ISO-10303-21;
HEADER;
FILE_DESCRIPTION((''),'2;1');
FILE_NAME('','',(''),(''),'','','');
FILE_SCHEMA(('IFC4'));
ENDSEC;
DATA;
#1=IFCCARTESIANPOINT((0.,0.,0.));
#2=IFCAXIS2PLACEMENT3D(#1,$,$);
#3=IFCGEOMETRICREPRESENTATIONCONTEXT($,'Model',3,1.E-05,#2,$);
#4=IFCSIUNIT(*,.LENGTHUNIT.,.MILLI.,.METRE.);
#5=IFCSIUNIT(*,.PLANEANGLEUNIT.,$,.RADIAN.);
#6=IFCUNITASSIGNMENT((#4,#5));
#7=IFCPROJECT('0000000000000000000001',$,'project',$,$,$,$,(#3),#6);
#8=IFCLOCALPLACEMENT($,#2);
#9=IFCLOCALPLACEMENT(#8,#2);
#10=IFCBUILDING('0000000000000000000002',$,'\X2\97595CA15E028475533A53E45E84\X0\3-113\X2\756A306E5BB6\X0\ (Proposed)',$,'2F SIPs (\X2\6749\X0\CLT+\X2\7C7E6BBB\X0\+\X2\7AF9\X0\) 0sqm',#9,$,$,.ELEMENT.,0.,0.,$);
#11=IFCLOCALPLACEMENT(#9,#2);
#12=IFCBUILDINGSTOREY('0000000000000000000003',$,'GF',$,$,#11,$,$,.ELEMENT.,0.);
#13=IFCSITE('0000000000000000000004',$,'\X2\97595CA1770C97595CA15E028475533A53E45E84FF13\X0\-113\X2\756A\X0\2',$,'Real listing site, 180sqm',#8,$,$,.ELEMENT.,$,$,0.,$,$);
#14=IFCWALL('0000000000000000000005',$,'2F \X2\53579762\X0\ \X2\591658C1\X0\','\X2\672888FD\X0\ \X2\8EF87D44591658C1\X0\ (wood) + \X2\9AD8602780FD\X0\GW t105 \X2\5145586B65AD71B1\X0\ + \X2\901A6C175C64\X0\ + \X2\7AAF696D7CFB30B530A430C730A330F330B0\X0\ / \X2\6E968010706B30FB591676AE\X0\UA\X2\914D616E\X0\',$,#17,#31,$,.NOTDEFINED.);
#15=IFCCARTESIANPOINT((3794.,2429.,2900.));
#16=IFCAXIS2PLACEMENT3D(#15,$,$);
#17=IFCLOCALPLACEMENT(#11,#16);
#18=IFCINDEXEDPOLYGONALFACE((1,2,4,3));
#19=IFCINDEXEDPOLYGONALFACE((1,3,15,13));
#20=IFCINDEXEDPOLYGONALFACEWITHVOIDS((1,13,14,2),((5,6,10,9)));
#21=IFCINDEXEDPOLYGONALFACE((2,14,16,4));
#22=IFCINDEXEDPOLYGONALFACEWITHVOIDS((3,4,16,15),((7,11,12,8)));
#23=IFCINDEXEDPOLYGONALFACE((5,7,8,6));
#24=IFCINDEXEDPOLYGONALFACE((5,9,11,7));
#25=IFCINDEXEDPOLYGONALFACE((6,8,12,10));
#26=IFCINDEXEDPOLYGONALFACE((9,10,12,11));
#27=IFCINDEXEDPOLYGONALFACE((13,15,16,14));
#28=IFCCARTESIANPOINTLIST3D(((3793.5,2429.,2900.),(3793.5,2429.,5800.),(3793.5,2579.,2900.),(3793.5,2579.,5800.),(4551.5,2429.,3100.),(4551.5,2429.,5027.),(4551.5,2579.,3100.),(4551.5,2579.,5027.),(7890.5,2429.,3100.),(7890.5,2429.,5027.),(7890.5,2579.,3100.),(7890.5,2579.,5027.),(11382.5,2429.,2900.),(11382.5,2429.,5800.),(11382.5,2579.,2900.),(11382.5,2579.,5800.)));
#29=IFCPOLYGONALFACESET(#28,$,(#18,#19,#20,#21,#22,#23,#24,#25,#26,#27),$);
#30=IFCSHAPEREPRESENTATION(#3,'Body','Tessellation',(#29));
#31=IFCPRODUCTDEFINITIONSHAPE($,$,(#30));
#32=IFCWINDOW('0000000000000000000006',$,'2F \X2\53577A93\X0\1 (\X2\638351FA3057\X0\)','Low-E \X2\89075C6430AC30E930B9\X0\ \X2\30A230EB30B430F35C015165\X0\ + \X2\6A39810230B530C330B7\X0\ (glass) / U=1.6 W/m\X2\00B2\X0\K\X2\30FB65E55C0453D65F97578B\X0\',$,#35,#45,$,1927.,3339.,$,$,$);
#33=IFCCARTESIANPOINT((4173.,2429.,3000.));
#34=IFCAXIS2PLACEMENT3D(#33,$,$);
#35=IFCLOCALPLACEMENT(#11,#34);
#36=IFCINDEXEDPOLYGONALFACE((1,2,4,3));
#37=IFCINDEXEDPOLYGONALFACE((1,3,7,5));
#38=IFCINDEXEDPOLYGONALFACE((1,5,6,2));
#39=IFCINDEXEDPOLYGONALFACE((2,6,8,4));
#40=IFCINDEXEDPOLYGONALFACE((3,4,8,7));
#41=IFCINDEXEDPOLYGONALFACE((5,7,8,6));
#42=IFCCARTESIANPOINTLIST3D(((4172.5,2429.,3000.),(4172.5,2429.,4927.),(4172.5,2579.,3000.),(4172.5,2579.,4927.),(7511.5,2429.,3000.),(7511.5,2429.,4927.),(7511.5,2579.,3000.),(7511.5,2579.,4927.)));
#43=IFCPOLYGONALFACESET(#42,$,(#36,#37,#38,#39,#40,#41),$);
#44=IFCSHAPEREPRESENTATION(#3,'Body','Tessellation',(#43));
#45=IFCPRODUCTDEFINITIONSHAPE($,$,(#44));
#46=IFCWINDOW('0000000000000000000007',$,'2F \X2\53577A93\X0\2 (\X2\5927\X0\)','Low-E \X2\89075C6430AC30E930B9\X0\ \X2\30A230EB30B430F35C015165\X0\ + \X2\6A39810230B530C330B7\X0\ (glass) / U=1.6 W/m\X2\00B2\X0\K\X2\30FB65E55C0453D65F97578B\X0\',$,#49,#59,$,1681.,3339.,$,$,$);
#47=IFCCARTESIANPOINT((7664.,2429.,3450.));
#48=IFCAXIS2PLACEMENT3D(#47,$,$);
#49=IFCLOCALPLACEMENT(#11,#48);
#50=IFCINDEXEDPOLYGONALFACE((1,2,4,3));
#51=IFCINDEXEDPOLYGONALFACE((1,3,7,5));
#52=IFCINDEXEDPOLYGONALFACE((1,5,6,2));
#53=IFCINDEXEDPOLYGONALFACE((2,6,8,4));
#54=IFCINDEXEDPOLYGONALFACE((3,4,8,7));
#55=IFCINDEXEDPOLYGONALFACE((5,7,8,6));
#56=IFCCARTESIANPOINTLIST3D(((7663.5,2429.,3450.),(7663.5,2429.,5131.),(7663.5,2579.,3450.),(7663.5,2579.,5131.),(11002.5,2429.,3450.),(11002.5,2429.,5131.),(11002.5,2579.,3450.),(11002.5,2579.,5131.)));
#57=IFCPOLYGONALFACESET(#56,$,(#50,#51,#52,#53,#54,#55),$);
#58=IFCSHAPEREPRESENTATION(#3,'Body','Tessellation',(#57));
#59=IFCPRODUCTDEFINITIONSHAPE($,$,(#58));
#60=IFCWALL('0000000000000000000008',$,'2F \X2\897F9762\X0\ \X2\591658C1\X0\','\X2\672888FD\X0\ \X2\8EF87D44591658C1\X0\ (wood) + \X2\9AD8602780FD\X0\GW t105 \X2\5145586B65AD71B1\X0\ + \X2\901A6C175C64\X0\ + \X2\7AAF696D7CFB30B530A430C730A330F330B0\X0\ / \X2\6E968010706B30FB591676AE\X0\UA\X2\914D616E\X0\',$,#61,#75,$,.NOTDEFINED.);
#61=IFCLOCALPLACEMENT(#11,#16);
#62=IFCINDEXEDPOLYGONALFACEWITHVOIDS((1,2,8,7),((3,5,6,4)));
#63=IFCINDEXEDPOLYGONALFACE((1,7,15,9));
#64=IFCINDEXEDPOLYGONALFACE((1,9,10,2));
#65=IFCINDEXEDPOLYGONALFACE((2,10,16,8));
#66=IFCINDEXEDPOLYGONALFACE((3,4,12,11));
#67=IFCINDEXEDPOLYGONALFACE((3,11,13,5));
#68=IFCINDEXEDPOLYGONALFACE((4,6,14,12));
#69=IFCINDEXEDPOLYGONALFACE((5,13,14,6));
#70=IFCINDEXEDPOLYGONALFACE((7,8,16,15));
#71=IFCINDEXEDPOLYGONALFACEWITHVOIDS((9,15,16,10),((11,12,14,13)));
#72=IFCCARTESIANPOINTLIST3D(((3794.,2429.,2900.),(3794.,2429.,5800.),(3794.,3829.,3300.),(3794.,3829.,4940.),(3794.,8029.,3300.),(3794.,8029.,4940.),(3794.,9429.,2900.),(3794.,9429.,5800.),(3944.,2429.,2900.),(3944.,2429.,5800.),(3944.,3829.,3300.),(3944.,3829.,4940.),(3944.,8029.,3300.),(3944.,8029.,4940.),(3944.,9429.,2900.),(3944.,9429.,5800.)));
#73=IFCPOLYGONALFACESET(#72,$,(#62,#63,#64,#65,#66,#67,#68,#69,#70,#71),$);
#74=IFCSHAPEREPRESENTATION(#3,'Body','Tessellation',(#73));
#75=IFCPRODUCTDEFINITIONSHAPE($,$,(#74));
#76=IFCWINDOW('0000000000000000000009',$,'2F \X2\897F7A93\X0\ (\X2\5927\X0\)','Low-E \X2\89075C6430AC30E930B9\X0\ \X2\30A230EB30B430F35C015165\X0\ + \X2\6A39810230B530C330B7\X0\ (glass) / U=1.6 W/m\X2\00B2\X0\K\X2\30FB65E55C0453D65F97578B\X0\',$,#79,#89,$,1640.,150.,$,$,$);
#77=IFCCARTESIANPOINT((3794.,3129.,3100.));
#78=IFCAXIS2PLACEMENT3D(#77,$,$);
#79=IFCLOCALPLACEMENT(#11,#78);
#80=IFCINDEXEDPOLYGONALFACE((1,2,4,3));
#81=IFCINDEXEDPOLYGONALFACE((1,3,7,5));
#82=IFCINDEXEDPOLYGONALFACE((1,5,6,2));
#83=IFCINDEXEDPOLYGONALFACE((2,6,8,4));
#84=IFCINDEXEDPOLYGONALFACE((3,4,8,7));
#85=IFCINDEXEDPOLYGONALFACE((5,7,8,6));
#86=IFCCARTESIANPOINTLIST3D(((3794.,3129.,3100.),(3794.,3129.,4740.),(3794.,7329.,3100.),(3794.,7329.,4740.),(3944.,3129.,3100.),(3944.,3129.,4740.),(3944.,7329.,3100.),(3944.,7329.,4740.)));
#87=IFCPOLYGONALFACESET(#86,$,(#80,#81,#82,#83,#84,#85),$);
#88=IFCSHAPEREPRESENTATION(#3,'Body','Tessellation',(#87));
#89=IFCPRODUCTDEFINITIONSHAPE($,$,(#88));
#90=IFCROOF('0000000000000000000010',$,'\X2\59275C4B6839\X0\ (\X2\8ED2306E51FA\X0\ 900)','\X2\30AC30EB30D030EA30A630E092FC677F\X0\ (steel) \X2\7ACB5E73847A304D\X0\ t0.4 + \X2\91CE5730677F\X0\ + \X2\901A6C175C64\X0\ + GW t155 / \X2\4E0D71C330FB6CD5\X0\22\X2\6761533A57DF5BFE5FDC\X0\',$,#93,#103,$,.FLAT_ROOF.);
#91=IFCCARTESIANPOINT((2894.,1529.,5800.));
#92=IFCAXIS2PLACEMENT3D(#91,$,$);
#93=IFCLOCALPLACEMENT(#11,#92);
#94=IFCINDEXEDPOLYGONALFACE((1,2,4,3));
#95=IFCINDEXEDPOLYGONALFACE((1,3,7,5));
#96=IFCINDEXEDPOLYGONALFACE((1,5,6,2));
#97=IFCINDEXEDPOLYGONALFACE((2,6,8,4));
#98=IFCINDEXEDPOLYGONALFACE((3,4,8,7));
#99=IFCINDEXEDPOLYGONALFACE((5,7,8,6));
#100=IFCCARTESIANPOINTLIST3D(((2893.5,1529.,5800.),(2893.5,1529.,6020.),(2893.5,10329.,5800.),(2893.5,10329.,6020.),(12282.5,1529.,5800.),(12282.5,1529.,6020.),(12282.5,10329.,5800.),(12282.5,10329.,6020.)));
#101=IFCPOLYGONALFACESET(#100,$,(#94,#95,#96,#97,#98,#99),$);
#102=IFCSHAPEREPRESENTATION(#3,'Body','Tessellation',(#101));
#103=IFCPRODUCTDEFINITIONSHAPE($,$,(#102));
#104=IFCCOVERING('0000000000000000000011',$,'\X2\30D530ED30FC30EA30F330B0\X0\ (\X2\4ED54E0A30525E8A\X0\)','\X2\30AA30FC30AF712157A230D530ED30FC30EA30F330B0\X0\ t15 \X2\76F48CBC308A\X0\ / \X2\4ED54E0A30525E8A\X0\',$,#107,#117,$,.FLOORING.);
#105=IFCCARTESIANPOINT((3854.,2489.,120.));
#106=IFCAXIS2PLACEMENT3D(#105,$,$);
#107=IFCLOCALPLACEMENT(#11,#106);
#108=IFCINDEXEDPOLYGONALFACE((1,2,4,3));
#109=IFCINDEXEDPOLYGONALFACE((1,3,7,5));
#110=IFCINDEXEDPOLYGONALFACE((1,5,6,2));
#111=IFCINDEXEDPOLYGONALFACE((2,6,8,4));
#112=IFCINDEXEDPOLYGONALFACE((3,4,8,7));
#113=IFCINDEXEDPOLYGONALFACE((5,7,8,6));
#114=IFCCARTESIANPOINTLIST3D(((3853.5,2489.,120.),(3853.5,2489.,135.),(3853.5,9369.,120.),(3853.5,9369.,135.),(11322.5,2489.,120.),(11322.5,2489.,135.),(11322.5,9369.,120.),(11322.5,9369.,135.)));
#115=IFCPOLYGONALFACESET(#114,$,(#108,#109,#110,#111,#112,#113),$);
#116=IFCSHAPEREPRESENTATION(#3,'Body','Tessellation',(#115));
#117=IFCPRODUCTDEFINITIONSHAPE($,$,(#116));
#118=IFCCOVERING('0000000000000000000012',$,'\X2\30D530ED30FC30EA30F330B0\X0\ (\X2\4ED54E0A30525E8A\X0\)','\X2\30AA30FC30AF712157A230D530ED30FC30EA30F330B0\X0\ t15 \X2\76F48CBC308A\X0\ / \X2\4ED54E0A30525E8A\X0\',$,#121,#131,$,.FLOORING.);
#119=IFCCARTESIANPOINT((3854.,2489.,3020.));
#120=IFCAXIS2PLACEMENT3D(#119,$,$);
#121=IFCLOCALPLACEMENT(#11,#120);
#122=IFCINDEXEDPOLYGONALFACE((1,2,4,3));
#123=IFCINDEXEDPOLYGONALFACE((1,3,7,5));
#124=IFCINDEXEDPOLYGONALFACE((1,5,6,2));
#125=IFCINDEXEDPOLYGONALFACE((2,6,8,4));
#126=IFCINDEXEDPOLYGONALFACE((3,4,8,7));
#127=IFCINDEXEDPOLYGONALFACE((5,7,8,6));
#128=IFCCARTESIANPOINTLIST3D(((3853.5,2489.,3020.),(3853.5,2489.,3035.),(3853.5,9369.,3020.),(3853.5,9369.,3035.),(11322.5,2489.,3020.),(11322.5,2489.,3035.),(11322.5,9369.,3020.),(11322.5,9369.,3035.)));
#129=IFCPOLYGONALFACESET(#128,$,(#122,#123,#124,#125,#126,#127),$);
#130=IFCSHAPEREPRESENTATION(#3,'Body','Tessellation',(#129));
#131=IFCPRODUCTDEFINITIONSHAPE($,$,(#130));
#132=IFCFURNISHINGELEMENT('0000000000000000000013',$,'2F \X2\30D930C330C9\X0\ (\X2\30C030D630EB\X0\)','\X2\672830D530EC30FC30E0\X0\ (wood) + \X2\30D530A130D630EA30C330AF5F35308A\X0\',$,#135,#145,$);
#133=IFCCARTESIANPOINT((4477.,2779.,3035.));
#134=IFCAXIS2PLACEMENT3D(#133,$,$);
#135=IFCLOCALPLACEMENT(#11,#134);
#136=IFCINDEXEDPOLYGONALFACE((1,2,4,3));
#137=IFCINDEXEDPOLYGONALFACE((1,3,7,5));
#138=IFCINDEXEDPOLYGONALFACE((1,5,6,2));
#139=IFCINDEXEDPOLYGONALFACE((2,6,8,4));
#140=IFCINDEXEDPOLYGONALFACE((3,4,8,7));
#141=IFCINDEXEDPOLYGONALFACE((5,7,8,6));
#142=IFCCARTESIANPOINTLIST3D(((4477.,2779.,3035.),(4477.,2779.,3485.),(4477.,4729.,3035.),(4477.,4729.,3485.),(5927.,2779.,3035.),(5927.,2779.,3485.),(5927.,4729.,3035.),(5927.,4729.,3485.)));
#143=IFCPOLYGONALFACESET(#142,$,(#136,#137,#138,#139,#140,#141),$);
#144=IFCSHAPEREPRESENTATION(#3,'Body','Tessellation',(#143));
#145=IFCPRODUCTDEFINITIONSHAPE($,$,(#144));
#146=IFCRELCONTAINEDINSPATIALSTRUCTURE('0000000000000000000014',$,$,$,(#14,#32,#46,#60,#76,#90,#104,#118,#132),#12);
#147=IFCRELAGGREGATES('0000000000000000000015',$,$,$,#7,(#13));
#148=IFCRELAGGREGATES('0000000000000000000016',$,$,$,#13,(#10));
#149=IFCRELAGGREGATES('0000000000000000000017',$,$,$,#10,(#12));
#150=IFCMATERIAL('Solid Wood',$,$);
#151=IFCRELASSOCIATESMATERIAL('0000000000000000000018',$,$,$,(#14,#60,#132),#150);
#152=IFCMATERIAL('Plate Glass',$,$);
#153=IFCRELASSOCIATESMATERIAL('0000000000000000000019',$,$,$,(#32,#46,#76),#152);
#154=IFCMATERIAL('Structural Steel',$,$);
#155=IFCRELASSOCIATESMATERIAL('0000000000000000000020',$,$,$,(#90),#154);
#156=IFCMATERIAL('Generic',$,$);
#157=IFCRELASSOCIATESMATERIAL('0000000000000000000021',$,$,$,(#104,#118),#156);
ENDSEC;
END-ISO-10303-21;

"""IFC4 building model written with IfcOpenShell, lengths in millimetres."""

from ifc_helpers import new_model, si_unit, frame, frame_2d, origin, place, context, project, spatial, rectangle, extrude, material, element, fill, save


model = new_model("IFC4")

# Units and contexts
model_context = context("Model", 3, precision=1e-05, world=origin())
ifc_project = project(units=[si_unit("LENGTHUNIT", "METRE", prefix="MILLI"), si_unit("PLANEANGLEUNIT", "RADIAN")], contexts=[model_context])

# Site, building, storey
site_placement = place(None, origin())
site = spatial("IfcSite", under=ifc_project, at=site_placement, Name="静岡県静岡市葵区古庄３-113番2", ObjectType="Real listing site, 180sqm", CompositionType="ELEMENT", RefElevation=0.0)
building_placement = place(site_placement, origin())
building = spatial("IfcBuilding", under=site, at=building_placement, Name="静岡市葵区古庄3-113番の家 (Proposed)", ObjectType="2F SIPs (杉CLT+籾殻+竹) 0sqm", CompositionType="ELEMENT", ElevationOfRefHeight=0.0, ElevationOfTerrain=0.0)
storey_placement = place(building_placement, origin())
storey = spatial("IfcBuildingStorey", under=building, at=storey_placement, Name="GF", CompositionType="ELEMENT", Elevation=0.0)

# Shared definitions
ifc_material_1 = material(Name="Solid Wood")

# Shared definitions
ifc_material_2 = material(Name="Plate Glass")

# Wall, openings, windows
wall_1_placement = place(storey_placement, frame((3794.0, 2429.0, 2900.0)))
wall_1 = element("IfcWall", 1, at=wall_1_placement, inside=storey, material=ifc_material_1, Name="2F 南面 外壁", Description="木製 軸組外壁 (wood) + 高性能GW t105 充填断熱 + 通気層 + 窯業系サイディング / 準耐火・外皮UA配慮", PredefinedType="NOTDEFINED", context=model_context, shape_type="SweptSolid", body=[
    extrude(rectangle(XDim=7589.0, YDim=150.0, at=frame_2d((3794.0, 75.0))), frame((3794.0, 2429.0, 2900.0)), (0.0, 0.0, 1.0), 2900.0),
])
opening_1_placement = place(storey_placement, frame((4173.0, 2429.0, 3000.0)))
opening_1 = element("IfcOpeningElement", 2, at=opening_1_placement, cuts=wall_1, PredefinedType="NOTDEFINED", context=model_context, shape_type="SweptSolid", body=[
    extrude(rectangle(XDim=3339.0, YDim=150.0, at=frame_2d((1669.0, 75.0))), frame((4173.0, 2429.0, 3000.0)), (0.0, 0.0, 1.0), 1927.0),
])
opening_2_placement = place(storey_placement, frame((7664.0, 2429.0, 3450.0)))
opening_2 = element("IfcOpeningElement", 3, at=opening_2_placement, cuts=wall_1, PredefinedType="NOTDEFINED", context=model_context, shape_type="SweptSolid", body=[
    extrude(rectangle(XDim=3339.0, YDim=150.0, at=frame_2d((1669.0, 75.0))), frame((7664.0, 2429.0, 3450.0)), (0.0, 0.0, 1.0), 1681.0),
])
window_1_placement = place(storey_placement, frame((4173.0, 2429.0, 3000.0)))
window_1 = element("IfcWindow", 4, at=window_1_placement, inside=storey, material=ifc_material_2, Name="2F 南窓1 (掃出し)", Description="Low-E 複層ガラス アルゴン封入 + 樹脂サッシ (glass) / U=1.6 W/m²K・日射取得型", OverallHeight=1927.0, OverallWidth=3339.0, context=model_context, shape_type="SweptSolid", body=[
    extrude(rectangle(XDim=3339.0, YDim=150.0, at=frame_2d((1669.0, 75.0))), frame((4173.0, 2429.0, 3000.0)), (0.0, 0.0, 1.0), 1927.0),
])
fill(opening_1, window_1)
window_2_placement = place(storey_placement, frame((7664.0, 2429.0, 3450.0)))
window_2 = element("IfcWindow", 5, at=window_2_placement, inside=storey, material=ifc_material_2, Name="2F 南窓2 (大)", Description="Low-E 複層ガラス アルゴン封入 + 樹脂サッシ (glass) / U=1.6 W/m²K・日射取得型", OverallHeight=1681.0, OverallWidth=3339.0, context=model_context, shape_type="SweptSolid", body=[
    extrude(rectangle(XDim=3339.0, YDim=150.0, at=frame_2d((1669.0, 75.0))), frame((7664.0, 2429.0, 3450.0)), (0.0, 0.0, 1.0), 1681.0),
])
fill(opening_2, window_2)

# Wall, opening, window
wall_2_placement = place(storey_placement, frame((3794.0, 2429.0, 2900.0)))
wall_2 = element("IfcWall", 6, at=wall_2_placement, inside=storey, material=ifc_material_1, Name="2F 西面 外壁", Description="木製 軸組外壁 (wood) + 高性能GW t105 充填断熱 + 通気層 + 窯業系サイディング / 準耐火・外皮UA配慮", PredefinedType="NOTDEFINED", context=model_context, shape_type="SweptSolid", body=[
    extrude(rectangle(XDim=150.0, YDim=7000.0, at=frame_2d((75.0, 3500.0))), frame((3794.0, 2429.0, 2900.0)), (0.0, 0.0, 1.0), 2900.0),
])
opening_3_placement = place(storey_placement, frame((3794.0, 3129.0, 3100.0)))
opening_3 = element("IfcOpeningElement", 7, at=opening_3_placement, cuts=wall_2, PredefinedType="NOTDEFINED", context=model_context, shape_type="SweptSolid", body=[
    extrude(rectangle(XDim=150.0, YDim=4200.0, at=frame_2d((75.0, 2100.0))), frame((3794.0, 3129.0, 3100.0)), (0.0, 0.0, 1.0), 1640.0),
])
window_3_placement = place(storey_placement, frame((3794.0, 3129.0, 3100.0)))
window_3 = element("IfcWindow", 8, at=window_3_placement, inside=storey, material=ifc_material_2, Name="2F 西窓 (大)", Description="Low-E 複層ガラス アルゴン封入 + 樹脂サッシ (glass) / U=1.6 W/m²K・日射取得型", OverallHeight=1640.0, OverallWidth=150.0, context=model_context, shape_type="SweptSolid", body=[
    extrude(rectangle(XDim=150.0, YDim=4200.0, at=frame_2d((75.0, 2100.0))), frame((3794.0, 3129.0, 3100.0)), (0.0, 0.0, 1.0), 1640.0),
])
fill(opening_3, window_3)

# Roof
ifc_material_3 = material(Name="Structural Steel")
roof_placement = place(storey_placement, frame((2894.0, 1529.0, 5800.0)))
element("IfcRoof", 9, at=roof_placement, inside=storey, material=ifc_material_3, Name="大屋根 (軒の出 900)", Description="ガルバリウム鋼板 (steel) 立平葺き t0.4 + 野地板 + 通気層 + GW t155 / 不燃・法22条区域対応", PredefinedType="FLAT_ROOF", context=model_context, shape_type="SweptSolid", body=[
    extrude(rectangle(XDim=9389.0, YDim=8800.0, at=frame_2d((4694.0, 4400.0))), frame((2894.0, 1529.0, 5800.0)), (0.0, 0.0, 1.0), 220.0),
])

# Coverings
ifc_material_4 = material(Name="Generic")
covering_1_placement = place(storey_placement, frame((3854.0, 2489.0, 120.0)))
element("IfcCovering", 10, at=covering_1_placement, inside=storey, material=ifc_material_4, Name="フローリング (仕上げ床)", Description="オーク無垢フローリング t15 直貼り / 仕上げ床", PredefinedType="FLOORING", context=model_context, shape_type="SweptSolid", body=[
    extrude(rectangle(XDim=7469.0, YDim=6880.0, at=frame_2d((3734.0, 3440.0))), frame((3854.0, 2489.0, 120.0)), (0.0, 0.0, 1.0), 15.0),
])
covering_2_placement = place(storey_placement, frame((3854.0, 2489.0, 3020.0)))
element("IfcCovering", 11, at=covering_2_placement, inside=storey, material=ifc_material_4, Name="フローリング (仕上げ床)", Description="オーク無垢フローリング t15 直貼り / 仕上げ床", PredefinedType="FLOORING", context=model_context, shape_type="SweptSolid", body=[
    extrude(rectangle(XDim=7469.0, YDim=6880.0, at=frame_2d((3734.0, 3440.0))), frame((3854.0, 2489.0, 3020.0)), (0.0, 0.0, 1.0), 15.0),
])

# Furnishing element
furnishing_placement = place(storey_placement, frame((4477.0, 2779.0, 3035.0)))
element("IfcFurnishingElement", 12, at=furnishing_placement, inside=storey, material=ifc_material_1, Name="2F ベッド (ダブル)", Description="木フレーム (wood) + ファブリック張り", context=model_context, shape_type="SweptSolid", body=[
    extrude(rectangle(XDim=1450.0, YDim=1950.0, at=frame_2d((725.0, 975.0))), frame((4477.0, 2779.0, 3035.0)), (0.0, 0.0, 1.0), 450.0),
])

save(model, "model.ifc")
